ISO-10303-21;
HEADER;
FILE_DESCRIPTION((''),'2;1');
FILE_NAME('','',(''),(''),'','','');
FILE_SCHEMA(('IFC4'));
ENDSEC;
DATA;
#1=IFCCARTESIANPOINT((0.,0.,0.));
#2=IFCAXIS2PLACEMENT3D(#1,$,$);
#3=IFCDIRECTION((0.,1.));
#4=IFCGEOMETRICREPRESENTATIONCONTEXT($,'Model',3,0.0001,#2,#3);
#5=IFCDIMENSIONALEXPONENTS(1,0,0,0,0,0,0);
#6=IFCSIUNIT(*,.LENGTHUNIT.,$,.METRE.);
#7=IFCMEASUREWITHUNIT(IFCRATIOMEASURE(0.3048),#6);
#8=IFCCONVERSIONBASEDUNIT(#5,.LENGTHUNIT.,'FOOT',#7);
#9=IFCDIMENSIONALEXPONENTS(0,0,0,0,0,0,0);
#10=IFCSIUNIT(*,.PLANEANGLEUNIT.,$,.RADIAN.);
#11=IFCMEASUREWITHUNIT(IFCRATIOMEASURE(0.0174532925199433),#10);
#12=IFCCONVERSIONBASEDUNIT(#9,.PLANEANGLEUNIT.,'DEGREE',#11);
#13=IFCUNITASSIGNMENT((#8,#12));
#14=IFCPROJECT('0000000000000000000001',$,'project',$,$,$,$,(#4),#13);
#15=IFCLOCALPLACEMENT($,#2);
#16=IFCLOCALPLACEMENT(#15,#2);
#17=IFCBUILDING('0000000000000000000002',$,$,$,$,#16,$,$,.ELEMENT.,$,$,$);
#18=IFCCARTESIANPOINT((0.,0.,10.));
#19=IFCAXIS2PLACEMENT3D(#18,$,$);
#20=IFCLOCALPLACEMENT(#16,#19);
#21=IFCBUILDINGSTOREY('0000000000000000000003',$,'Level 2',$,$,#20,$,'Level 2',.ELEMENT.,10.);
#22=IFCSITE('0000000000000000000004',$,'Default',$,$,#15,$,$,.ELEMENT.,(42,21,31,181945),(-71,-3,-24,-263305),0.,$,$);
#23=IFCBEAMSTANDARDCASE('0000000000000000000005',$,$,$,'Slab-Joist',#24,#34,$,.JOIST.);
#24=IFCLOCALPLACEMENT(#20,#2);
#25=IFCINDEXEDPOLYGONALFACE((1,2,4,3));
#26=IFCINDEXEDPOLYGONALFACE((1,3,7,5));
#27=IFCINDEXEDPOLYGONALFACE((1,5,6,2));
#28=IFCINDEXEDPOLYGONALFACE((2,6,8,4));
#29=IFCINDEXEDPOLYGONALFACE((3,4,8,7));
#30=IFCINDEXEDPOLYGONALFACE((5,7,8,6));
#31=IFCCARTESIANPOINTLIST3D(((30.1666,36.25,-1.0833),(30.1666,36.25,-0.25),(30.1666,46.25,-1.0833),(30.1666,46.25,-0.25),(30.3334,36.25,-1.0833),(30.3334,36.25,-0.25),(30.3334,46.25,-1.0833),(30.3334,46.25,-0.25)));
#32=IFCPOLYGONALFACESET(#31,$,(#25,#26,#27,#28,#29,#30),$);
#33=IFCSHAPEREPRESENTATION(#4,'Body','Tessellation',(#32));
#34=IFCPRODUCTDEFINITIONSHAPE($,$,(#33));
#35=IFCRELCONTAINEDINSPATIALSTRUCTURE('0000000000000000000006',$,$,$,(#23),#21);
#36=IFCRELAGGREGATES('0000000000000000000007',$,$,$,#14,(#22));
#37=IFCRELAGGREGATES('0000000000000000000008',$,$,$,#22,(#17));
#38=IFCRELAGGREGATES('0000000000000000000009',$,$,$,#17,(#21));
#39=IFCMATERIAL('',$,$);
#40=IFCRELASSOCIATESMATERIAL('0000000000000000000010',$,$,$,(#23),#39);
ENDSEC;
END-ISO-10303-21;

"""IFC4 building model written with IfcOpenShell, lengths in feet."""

from ifc_helpers import new_model, entity, si_unit, converted_unit, direction, frame, origin, origin_with_axes, place, context, project, spatial, rectangle, extrude, material, element, save


model = new_model("IFC4")

# Units and contexts
model_context = context("Model", 3, precision=0.0001, world=origin(), true_north=direction((0.0, 1.0)))
ifc_project = project(units=[converted_unit("LENGTHUNIT", "FOOT", entity("IfcRatioMeasure", 0.3048), si_unit("LENGTHUNIT", "METRE"), dimensions=[1, 0, 0, 0, 0, 0, 0]), converted_unit("PLANEANGLEUNIT", "DEGREE", entity("IfcRatioMeasure", 0.0174532925199433), si_unit("PLANEANGLEUNIT", "RADIAN"), dimensions=[0, 0, 0, 0, 0, 0, 0])], contexts=[model_context])

# Site, building, storey
site_placement = place(None, origin())
site = spatial("IfcSite", under=ifc_project, at=site_placement, Name="Default", CompositionType="ELEMENT", RefLatitude=(42, 21, 31, 181945), RefLongitude=(-71, -3, -24, -263305), RefElevation=0.0)
building_placement = place(site_placement, origin())
building = spatial("IfcBuilding", under=site, at=building_placement, CompositionType="ELEMENT")
storey_placement = place(building_placement, frame((0.0, 0.0, 10.0)))
storey = spatial("IfcBuildingStorey", under=building, at=storey_placement, Name="Level 2", LongName="Level 2", CompositionType="ELEMENT", Elevation=10.0)

# Beam
ifc_material = material(Name="")
placement_1 = place(storey_placement, frame((30.25, 36.25, 0.0), z_axis=(0.0, 0.0, 1.0), x_axis=(1.0, 0.0, 0.0)))
beam_1_placement = place(placement_1, frame((0.0, 0.0, -0.6667), z_axis=(0.0, 1.0, 0.0), x_axis=(-1.0, 0.0, 0.0)))
element("IfcBeamStandardCase", 1, at=beam_1_placement, inside=storey, material=ifc_material, ObjectType="Slab-Joist", PredefinedType="JOIST", context=model_context, shape_type="SweptSolid", body=[
    extrude(rectangle(XDim=0.1667, YDim=0.8333), origin_with_axes(), (0.0, 0.0, 1.0), 10.0),
])

save(model, "model.ifc")
